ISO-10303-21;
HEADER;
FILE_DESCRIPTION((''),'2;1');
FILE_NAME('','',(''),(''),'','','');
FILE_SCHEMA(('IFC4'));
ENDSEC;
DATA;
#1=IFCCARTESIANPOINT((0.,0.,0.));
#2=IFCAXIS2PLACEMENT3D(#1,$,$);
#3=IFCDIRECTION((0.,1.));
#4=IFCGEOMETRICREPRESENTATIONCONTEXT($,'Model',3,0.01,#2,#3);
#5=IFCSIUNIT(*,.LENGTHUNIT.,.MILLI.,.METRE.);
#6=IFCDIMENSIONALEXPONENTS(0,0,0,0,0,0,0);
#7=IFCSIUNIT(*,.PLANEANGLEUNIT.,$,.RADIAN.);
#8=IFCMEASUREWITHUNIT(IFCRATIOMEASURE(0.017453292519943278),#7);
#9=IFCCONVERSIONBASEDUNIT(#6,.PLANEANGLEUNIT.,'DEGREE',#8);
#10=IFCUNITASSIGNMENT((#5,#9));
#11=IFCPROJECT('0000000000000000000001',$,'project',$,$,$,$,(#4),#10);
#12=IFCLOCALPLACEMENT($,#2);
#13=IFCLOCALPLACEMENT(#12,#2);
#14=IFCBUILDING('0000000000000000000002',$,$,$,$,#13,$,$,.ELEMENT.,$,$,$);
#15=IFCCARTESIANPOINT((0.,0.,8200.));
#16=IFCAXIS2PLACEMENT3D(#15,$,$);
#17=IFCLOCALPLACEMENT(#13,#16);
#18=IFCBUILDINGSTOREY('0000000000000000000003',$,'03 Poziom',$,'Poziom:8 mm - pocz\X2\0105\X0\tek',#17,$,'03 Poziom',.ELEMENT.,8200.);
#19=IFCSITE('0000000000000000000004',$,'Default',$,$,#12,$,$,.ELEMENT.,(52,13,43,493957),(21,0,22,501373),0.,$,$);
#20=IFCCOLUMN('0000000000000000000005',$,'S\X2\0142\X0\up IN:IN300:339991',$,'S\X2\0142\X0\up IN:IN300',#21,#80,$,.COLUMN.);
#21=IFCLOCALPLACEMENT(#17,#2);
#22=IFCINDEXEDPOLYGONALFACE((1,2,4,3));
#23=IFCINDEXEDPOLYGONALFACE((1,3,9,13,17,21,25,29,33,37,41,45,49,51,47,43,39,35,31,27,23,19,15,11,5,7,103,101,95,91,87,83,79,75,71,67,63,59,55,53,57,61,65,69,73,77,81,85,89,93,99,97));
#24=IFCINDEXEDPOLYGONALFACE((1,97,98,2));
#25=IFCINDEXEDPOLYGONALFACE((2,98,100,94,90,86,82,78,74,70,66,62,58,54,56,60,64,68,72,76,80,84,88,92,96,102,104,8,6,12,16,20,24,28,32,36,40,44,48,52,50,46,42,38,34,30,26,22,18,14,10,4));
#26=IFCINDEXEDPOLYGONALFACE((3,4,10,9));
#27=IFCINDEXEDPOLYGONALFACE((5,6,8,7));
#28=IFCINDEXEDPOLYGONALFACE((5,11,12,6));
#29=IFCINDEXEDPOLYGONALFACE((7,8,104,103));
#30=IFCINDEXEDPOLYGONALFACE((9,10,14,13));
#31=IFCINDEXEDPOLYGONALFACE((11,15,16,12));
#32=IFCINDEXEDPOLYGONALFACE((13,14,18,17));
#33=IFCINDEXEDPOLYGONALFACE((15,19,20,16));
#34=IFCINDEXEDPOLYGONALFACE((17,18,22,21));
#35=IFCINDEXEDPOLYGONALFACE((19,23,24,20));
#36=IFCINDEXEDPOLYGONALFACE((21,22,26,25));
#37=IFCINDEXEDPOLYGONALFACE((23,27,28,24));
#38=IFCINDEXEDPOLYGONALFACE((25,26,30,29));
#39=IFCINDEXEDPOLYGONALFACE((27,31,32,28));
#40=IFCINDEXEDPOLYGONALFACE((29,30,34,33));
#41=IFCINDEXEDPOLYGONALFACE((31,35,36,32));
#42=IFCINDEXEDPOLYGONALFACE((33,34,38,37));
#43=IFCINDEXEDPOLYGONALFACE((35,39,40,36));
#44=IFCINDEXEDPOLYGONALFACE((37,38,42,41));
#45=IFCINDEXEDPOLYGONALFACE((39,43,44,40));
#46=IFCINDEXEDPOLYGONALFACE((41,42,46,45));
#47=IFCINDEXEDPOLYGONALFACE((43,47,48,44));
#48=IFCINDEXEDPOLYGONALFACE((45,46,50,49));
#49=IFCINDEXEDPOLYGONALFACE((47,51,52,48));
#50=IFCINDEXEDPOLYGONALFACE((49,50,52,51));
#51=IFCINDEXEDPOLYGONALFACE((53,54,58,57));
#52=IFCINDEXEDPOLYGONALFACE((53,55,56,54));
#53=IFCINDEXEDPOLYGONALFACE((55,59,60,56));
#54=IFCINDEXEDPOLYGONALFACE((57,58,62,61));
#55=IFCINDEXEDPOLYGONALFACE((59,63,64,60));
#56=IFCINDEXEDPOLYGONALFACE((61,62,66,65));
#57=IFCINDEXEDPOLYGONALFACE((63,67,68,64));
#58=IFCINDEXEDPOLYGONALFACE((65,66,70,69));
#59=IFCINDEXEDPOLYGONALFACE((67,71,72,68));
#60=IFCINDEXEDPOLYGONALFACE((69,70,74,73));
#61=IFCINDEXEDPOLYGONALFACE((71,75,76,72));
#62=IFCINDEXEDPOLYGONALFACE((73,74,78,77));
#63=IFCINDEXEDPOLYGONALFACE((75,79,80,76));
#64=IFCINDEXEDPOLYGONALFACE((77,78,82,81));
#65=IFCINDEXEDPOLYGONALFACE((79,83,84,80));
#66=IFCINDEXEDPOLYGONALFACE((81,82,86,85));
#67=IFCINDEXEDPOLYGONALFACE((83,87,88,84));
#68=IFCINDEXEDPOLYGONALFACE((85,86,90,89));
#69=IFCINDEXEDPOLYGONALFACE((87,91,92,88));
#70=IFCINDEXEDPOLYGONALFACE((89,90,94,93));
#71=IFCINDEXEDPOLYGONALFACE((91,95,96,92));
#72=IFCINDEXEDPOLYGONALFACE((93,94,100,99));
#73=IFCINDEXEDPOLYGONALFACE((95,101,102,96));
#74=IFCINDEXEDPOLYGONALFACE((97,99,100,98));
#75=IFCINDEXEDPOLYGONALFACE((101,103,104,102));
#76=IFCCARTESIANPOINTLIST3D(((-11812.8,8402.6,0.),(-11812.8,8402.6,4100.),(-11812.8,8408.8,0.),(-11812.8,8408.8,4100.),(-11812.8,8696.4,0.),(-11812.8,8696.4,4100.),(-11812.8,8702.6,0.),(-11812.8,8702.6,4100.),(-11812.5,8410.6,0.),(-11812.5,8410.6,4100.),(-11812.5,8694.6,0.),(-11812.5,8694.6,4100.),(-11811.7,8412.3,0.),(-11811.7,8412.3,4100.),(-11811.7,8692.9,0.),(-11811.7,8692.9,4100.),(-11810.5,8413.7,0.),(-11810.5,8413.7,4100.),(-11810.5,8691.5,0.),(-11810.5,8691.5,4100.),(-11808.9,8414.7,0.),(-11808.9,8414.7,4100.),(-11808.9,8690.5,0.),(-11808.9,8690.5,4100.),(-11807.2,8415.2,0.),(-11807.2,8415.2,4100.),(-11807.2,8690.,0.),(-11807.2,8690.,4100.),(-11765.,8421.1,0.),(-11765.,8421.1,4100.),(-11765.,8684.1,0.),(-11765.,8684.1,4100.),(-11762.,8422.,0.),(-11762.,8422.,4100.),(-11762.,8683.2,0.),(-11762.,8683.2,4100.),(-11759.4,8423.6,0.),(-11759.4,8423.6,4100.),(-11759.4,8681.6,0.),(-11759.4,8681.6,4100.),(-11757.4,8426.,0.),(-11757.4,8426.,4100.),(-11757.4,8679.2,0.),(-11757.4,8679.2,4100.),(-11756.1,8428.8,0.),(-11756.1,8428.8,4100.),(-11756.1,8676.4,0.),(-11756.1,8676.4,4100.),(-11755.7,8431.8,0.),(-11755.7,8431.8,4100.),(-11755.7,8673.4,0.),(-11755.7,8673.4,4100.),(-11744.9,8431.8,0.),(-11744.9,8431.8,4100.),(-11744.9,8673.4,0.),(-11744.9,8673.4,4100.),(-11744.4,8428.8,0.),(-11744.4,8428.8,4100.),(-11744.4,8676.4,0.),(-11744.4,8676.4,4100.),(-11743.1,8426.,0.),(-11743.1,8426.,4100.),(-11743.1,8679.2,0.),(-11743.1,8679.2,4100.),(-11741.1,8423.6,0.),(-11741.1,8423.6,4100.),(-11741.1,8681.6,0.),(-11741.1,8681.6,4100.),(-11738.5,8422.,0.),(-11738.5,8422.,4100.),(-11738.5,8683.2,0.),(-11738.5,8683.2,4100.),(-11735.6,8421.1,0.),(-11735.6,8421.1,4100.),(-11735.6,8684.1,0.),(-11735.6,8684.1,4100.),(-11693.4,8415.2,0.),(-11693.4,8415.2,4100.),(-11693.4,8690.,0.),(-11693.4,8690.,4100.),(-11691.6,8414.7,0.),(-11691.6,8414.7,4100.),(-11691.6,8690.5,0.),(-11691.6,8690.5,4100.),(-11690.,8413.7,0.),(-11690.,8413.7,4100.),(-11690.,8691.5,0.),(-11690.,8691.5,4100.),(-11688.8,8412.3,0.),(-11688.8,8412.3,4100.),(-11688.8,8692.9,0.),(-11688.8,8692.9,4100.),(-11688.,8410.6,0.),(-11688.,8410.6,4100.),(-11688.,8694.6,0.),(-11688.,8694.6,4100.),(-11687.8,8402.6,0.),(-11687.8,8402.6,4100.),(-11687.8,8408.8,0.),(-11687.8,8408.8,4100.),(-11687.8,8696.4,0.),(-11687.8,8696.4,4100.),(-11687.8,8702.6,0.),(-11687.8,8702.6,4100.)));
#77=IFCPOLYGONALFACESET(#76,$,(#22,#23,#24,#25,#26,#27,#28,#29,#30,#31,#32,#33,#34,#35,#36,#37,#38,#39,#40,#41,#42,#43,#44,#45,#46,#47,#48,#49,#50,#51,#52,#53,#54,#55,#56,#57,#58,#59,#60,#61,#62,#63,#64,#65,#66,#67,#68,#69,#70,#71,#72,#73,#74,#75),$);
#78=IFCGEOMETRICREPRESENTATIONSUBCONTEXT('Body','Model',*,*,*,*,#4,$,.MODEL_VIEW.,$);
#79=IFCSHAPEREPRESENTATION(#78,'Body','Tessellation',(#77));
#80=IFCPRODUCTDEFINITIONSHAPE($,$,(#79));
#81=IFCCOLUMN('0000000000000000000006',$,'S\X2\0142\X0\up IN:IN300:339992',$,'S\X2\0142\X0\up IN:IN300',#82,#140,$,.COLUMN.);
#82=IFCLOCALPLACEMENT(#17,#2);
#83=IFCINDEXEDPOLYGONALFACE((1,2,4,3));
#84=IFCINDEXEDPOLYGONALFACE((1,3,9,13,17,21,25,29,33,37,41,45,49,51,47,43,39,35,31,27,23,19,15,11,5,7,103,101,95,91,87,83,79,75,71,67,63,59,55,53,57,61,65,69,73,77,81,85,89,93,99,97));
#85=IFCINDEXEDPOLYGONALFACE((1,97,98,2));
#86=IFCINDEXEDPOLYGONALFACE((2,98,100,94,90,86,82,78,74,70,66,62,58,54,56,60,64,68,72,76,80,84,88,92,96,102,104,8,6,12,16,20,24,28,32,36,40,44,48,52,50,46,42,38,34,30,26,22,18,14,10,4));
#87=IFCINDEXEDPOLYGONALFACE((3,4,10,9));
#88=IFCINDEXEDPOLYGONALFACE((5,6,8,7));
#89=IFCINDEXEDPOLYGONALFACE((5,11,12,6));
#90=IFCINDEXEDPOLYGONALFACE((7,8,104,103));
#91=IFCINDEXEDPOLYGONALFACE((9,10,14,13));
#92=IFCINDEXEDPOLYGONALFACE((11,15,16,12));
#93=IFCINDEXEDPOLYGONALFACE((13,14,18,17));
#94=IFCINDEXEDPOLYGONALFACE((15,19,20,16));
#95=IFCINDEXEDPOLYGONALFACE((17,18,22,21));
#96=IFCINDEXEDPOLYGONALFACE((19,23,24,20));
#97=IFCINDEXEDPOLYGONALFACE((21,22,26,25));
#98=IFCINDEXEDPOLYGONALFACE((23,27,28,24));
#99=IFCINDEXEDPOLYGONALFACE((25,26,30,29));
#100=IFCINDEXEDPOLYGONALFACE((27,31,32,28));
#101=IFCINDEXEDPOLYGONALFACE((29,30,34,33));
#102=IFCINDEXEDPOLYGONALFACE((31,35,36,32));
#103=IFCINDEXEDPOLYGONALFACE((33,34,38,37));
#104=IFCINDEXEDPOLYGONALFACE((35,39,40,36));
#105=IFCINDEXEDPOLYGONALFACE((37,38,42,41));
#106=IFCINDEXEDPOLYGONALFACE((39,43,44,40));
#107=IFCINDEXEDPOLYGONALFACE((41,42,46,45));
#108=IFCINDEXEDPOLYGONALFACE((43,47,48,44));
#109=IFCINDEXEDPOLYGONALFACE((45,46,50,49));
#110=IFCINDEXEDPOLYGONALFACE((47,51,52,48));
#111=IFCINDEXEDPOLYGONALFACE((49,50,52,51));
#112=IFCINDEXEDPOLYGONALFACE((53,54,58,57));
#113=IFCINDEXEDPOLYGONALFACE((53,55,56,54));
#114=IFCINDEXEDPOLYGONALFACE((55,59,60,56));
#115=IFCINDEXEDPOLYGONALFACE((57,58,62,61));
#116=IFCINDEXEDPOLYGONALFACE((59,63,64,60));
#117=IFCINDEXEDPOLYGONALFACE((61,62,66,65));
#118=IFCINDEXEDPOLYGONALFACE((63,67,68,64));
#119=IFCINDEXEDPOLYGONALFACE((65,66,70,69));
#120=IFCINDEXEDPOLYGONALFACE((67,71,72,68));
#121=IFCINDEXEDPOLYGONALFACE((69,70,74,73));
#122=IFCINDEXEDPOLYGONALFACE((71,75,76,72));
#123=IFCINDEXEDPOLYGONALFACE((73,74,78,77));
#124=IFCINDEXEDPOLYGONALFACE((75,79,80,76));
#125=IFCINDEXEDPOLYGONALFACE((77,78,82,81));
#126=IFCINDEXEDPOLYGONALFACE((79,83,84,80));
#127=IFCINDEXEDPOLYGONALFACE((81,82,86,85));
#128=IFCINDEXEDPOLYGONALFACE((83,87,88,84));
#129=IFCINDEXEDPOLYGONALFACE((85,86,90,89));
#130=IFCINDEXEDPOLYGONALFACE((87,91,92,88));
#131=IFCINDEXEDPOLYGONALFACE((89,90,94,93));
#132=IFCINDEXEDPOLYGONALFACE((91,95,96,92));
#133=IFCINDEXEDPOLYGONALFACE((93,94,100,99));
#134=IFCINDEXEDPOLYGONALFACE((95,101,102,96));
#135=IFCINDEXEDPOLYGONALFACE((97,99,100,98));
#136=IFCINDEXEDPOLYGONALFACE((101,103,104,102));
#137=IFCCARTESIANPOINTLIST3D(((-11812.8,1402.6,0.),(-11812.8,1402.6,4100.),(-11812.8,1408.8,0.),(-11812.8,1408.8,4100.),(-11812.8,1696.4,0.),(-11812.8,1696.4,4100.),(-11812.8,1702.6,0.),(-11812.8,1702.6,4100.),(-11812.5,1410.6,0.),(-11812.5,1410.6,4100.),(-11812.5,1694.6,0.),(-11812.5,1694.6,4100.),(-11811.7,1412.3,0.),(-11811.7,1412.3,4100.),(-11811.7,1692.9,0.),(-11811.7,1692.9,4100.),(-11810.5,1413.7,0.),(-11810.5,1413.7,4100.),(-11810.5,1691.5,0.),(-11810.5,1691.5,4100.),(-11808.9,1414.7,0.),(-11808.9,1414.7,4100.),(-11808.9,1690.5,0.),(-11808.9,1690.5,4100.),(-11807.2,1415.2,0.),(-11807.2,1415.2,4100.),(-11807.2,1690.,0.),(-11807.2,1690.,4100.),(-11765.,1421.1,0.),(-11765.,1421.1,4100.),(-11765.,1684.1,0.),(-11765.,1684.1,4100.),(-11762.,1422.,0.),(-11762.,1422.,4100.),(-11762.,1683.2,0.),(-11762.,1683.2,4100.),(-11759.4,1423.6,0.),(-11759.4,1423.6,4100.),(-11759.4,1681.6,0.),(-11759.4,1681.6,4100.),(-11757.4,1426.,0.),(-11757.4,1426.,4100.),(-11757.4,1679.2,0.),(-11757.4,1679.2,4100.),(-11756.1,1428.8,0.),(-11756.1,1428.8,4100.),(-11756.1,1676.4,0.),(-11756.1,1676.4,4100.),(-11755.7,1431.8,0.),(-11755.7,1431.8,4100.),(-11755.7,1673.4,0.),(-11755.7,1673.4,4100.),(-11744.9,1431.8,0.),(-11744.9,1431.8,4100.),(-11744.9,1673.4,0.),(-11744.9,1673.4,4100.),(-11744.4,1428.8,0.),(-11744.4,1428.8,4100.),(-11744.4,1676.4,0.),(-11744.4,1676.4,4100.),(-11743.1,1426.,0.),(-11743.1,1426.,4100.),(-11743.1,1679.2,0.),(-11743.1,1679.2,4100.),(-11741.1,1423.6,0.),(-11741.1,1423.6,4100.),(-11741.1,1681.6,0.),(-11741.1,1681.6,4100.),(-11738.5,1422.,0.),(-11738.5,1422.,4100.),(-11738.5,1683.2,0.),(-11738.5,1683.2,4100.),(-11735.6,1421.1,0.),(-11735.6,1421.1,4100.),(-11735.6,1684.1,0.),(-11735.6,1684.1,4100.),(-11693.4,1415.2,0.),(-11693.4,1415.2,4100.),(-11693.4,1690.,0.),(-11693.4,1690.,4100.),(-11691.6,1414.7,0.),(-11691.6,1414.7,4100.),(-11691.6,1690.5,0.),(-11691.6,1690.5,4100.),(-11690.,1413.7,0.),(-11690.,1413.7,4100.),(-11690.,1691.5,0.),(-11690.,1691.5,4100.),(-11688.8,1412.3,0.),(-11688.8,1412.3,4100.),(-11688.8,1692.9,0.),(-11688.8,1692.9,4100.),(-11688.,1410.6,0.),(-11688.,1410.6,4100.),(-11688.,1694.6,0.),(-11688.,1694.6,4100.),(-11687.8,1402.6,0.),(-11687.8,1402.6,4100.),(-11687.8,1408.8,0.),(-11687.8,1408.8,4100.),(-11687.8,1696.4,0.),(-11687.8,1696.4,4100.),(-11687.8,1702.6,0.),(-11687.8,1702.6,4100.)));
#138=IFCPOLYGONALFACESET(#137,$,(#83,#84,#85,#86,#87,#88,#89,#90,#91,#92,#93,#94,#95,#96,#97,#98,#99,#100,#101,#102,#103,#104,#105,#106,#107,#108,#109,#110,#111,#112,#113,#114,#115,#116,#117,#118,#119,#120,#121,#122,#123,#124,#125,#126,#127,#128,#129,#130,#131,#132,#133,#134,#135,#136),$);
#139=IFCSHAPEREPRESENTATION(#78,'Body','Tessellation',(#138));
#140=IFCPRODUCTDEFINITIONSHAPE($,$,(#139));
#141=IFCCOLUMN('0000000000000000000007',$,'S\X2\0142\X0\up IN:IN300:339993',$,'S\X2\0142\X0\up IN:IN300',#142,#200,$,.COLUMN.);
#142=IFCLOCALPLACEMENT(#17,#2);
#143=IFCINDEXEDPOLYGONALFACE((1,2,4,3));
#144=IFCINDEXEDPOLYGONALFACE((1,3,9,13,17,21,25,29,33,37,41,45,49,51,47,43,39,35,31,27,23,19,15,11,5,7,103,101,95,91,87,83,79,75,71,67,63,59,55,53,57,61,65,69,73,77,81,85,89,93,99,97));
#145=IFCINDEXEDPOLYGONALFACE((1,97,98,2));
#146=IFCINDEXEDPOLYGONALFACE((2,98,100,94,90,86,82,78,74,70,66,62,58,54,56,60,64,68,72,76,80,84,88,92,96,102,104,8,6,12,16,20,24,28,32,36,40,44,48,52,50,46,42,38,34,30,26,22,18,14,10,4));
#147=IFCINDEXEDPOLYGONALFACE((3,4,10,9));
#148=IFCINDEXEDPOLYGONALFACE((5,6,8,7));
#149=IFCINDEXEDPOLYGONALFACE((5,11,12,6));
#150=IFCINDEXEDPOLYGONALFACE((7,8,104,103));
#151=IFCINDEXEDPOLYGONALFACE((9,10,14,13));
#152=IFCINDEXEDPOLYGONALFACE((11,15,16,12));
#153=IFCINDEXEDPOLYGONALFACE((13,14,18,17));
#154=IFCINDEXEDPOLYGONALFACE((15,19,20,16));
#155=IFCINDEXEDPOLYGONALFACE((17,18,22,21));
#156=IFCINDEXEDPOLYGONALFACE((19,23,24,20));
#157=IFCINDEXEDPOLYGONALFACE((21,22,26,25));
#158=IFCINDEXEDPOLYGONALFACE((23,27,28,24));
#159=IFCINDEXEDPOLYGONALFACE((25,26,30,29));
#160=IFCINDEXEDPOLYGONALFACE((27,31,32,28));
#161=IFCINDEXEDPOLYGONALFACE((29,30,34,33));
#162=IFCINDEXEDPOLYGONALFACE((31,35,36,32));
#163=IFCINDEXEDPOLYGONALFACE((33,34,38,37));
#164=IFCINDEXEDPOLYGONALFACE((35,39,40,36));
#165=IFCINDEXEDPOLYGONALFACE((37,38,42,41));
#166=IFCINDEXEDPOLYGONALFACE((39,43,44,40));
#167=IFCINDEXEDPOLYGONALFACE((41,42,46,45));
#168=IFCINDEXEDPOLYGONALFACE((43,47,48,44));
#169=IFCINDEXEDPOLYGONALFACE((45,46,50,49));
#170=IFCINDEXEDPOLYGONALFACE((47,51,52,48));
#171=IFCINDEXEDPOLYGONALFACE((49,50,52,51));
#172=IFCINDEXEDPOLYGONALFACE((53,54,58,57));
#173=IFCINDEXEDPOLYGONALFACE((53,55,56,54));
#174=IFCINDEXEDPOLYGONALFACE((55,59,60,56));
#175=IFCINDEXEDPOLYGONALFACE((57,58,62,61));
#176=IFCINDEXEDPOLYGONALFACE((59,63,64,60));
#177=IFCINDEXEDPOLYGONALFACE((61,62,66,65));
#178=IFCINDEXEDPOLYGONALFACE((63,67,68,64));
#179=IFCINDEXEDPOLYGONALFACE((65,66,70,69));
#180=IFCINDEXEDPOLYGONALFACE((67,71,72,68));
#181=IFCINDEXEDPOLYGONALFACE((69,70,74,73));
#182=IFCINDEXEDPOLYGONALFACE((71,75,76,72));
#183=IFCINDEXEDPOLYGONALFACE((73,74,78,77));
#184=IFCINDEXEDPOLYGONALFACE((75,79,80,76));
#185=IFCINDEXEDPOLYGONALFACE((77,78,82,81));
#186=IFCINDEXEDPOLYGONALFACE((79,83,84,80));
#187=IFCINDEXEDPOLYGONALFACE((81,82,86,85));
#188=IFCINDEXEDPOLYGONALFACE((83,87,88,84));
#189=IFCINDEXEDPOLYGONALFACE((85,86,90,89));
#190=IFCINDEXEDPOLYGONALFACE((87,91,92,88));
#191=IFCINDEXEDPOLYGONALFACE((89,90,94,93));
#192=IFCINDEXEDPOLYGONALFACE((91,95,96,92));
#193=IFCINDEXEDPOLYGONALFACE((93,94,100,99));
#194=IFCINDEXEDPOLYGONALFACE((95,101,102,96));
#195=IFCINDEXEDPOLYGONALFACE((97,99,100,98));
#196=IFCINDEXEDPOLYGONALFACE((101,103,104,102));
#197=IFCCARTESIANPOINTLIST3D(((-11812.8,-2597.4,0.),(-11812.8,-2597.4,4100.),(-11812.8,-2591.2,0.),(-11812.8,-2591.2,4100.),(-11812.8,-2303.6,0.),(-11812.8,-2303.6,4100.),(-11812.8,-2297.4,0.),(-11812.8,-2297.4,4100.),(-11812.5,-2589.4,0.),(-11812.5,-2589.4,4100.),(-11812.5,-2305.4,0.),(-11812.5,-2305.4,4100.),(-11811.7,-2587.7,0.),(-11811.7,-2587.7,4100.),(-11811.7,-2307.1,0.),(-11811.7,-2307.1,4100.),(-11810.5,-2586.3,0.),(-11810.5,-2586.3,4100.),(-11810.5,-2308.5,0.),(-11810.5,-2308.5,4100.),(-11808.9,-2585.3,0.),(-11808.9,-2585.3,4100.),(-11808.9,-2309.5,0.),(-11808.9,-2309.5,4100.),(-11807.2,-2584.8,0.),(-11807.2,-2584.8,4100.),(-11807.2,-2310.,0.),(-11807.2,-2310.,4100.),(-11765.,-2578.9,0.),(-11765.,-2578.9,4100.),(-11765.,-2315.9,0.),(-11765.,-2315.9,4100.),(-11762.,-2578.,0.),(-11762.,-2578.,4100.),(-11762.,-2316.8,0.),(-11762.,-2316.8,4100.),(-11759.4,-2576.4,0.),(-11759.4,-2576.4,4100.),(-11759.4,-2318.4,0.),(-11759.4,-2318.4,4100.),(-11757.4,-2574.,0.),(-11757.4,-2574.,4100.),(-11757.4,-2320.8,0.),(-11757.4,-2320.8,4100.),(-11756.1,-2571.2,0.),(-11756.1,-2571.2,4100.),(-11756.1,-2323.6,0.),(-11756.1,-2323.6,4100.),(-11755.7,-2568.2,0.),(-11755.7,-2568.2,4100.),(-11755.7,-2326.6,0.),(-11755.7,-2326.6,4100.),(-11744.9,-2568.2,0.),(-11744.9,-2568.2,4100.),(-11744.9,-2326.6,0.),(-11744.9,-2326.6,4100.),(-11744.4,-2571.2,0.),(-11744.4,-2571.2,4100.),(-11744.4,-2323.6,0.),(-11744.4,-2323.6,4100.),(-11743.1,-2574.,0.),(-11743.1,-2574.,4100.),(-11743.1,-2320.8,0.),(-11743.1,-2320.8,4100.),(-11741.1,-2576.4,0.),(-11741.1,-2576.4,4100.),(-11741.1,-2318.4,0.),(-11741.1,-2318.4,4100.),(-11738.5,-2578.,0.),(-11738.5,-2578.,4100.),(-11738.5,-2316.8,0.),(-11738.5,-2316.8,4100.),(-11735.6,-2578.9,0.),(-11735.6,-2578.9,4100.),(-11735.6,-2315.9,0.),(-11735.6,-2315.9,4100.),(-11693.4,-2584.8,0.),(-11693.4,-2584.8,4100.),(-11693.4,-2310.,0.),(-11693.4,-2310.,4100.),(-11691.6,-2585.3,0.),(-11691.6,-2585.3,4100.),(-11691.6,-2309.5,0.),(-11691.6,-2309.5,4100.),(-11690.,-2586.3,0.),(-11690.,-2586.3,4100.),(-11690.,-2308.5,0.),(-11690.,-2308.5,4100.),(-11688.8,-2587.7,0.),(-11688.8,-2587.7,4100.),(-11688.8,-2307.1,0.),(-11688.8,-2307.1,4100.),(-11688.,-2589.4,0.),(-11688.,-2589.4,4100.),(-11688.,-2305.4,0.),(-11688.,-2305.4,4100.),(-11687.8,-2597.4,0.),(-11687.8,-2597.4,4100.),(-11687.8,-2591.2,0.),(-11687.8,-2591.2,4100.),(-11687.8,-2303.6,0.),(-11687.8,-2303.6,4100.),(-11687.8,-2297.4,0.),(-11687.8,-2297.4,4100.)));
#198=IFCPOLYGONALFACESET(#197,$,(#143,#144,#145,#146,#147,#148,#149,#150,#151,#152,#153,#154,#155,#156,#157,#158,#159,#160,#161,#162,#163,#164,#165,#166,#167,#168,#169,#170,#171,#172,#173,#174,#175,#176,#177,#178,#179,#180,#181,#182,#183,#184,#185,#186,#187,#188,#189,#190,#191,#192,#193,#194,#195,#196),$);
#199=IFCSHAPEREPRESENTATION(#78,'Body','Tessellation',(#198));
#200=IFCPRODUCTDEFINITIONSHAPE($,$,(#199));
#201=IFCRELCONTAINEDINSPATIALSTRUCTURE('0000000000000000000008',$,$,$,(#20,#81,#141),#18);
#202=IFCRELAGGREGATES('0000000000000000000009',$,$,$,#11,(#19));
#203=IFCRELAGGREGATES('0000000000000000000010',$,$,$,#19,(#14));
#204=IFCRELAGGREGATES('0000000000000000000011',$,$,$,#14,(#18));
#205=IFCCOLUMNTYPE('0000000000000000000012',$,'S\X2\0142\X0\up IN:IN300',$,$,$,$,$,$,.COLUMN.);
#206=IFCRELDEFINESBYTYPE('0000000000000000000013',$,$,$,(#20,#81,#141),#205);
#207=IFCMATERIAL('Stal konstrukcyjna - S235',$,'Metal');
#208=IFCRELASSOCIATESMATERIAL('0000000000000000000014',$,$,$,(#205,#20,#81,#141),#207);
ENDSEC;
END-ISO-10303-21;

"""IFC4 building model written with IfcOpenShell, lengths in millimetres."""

from ifc_helpers import new_model, entity, si_unit, converted_unit, direction, frame, origin, place, context, subcontext, project, spatial, line, arc, indexed_curve, outline, extrude, source, transform, mapped, material, type_object, type_shapes, element, save


model = new_model("IFC4")

# Units and contexts
model_context = context("Model", 3, precision=0.01, world=origin(), true_north=direction((0.0, 1.0)))
body_context = subcontext(model_context, "Body", "Model", "MODEL_VIEW")
ifc_project = project(units=[si_unit("LENGTHUNIT", "METRE", prefix="MILLI"), converted_unit("PLANEANGLEUNIT", "DEGREE", entity("IfcRatioMeasure", 0.017453292519943278), si_unit("PLANEANGLEUNIT", "RADIAN"), dimensions=[0, 0, 0, 0, 0, 0, 0])], contexts=[model_context])

# Site, building, storey
site_placement = place(None, origin())
site = spatial("IfcSite", under=ifc_project, at=site_placement, Name="Default", CompositionType="ELEMENT", RefLatitude=(52, 13, 43, 493957), RefLongitude=(21, 0, 22, 501373), RefElevation=0.0)
building_placement = place(site_placement, origin())
building = spatial("IfcBuilding", under=site, at=building_placement, CompositionType="ELEMENT")
storey_placement = place(building_placement, frame((0.0, 0.0, 8200.0)))
storey = spatial("IfcBuildingStorey", under=building, at=storey_placement, Name="03 Poziom", ObjectType="Poziom:8 mm - początek", LongName="03 Poziom", CompositionType="ELEMENT", Elevation=8200.0)

# Columns
ifc_material_1 = material(Name="Stal konstrukcyjna - S235", Category="Metal")
column_type = type_object("IfcColumnType", Name="Słup IN:IN300", PredefinedType="COLUMN", material=ifc_material_1)
shared_shape_1 = source(origin(), body_context, "Body", "SweptSolid", [
    extrude(outline(indexed_curve([(143.8, -62.5), (150.0, -62.5), (150.0, 62.5), (143.8, 62.5), (139.6, 60.9), (137.4, 56.9), (131.5, 14.7), (127.9, 8.1), (120.8, 5.4), (-120.8, 5.4), (-127.9, 8.1), (-131.5, 14.7), (-137.4, 56.9), (-139.6, 60.9), (-143.8, 62.5), (-150.0, 62.5), (-150.0, -62.5), (-143.8, -62.5), (-139.6, -60.9), (-137.4, -56.9), (-131.5, -14.7), (-127.9, -8.1), (-120.8, -5.4), (120.8, -5.4), (127.9, -8.1), (131.5, -14.7), (137.4, -56.9), (139.6, -60.9)], segments=[line(1, 2, 3, 4), arc(4, 5, 6), line(6, 7), arc(7, 8, 9), line(9, 10), arc(10, 11, 12), line(12, 13), arc(13, 14, 15), line(15, 16, 17, 18), arc(18, 19, 20), line(20, 21), arc(21, 22, 23), line(23, 24), arc(24, 25, 26), line(26, 27), arc(27, 28, 1)], self_intersect=False)), frame((0.0, 0.0, 8200.0), z_axis=(0.0, 0.0, 1.0), x_axis=(0.0, -1.0, 0.0)), (0.0, 0.0, 1.0), 4100.0),
])
type_shapes(column_type, [shared_shape_1])
for number, where, name in (
    (1, (-11750.3, 8552.6, -8200.0), "Słup IN:IN300:339991"),
    (2, (-11750.3, 1552.6, -8200.0), "Słup IN:IN300:339992"),
    (3, (-11750.3, -2447.4, -8200.0), "Słup IN:IN300:339993"),
):
    element("IfcColumn", number, at=place(storey_placement, frame(where)), inside=storey, type_object=column_type, material=ifc_material_1, Name=name, ObjectType="Słup IN:IN300", PredefinedType="COLUMN", context=body_context, shape_type="MappedRepresentation", body=[
        mapped(shared_shape_1, transform((0.0, 0.0, 0.0), scale=1.0)),
    ])

save(model, "model.ifc")
